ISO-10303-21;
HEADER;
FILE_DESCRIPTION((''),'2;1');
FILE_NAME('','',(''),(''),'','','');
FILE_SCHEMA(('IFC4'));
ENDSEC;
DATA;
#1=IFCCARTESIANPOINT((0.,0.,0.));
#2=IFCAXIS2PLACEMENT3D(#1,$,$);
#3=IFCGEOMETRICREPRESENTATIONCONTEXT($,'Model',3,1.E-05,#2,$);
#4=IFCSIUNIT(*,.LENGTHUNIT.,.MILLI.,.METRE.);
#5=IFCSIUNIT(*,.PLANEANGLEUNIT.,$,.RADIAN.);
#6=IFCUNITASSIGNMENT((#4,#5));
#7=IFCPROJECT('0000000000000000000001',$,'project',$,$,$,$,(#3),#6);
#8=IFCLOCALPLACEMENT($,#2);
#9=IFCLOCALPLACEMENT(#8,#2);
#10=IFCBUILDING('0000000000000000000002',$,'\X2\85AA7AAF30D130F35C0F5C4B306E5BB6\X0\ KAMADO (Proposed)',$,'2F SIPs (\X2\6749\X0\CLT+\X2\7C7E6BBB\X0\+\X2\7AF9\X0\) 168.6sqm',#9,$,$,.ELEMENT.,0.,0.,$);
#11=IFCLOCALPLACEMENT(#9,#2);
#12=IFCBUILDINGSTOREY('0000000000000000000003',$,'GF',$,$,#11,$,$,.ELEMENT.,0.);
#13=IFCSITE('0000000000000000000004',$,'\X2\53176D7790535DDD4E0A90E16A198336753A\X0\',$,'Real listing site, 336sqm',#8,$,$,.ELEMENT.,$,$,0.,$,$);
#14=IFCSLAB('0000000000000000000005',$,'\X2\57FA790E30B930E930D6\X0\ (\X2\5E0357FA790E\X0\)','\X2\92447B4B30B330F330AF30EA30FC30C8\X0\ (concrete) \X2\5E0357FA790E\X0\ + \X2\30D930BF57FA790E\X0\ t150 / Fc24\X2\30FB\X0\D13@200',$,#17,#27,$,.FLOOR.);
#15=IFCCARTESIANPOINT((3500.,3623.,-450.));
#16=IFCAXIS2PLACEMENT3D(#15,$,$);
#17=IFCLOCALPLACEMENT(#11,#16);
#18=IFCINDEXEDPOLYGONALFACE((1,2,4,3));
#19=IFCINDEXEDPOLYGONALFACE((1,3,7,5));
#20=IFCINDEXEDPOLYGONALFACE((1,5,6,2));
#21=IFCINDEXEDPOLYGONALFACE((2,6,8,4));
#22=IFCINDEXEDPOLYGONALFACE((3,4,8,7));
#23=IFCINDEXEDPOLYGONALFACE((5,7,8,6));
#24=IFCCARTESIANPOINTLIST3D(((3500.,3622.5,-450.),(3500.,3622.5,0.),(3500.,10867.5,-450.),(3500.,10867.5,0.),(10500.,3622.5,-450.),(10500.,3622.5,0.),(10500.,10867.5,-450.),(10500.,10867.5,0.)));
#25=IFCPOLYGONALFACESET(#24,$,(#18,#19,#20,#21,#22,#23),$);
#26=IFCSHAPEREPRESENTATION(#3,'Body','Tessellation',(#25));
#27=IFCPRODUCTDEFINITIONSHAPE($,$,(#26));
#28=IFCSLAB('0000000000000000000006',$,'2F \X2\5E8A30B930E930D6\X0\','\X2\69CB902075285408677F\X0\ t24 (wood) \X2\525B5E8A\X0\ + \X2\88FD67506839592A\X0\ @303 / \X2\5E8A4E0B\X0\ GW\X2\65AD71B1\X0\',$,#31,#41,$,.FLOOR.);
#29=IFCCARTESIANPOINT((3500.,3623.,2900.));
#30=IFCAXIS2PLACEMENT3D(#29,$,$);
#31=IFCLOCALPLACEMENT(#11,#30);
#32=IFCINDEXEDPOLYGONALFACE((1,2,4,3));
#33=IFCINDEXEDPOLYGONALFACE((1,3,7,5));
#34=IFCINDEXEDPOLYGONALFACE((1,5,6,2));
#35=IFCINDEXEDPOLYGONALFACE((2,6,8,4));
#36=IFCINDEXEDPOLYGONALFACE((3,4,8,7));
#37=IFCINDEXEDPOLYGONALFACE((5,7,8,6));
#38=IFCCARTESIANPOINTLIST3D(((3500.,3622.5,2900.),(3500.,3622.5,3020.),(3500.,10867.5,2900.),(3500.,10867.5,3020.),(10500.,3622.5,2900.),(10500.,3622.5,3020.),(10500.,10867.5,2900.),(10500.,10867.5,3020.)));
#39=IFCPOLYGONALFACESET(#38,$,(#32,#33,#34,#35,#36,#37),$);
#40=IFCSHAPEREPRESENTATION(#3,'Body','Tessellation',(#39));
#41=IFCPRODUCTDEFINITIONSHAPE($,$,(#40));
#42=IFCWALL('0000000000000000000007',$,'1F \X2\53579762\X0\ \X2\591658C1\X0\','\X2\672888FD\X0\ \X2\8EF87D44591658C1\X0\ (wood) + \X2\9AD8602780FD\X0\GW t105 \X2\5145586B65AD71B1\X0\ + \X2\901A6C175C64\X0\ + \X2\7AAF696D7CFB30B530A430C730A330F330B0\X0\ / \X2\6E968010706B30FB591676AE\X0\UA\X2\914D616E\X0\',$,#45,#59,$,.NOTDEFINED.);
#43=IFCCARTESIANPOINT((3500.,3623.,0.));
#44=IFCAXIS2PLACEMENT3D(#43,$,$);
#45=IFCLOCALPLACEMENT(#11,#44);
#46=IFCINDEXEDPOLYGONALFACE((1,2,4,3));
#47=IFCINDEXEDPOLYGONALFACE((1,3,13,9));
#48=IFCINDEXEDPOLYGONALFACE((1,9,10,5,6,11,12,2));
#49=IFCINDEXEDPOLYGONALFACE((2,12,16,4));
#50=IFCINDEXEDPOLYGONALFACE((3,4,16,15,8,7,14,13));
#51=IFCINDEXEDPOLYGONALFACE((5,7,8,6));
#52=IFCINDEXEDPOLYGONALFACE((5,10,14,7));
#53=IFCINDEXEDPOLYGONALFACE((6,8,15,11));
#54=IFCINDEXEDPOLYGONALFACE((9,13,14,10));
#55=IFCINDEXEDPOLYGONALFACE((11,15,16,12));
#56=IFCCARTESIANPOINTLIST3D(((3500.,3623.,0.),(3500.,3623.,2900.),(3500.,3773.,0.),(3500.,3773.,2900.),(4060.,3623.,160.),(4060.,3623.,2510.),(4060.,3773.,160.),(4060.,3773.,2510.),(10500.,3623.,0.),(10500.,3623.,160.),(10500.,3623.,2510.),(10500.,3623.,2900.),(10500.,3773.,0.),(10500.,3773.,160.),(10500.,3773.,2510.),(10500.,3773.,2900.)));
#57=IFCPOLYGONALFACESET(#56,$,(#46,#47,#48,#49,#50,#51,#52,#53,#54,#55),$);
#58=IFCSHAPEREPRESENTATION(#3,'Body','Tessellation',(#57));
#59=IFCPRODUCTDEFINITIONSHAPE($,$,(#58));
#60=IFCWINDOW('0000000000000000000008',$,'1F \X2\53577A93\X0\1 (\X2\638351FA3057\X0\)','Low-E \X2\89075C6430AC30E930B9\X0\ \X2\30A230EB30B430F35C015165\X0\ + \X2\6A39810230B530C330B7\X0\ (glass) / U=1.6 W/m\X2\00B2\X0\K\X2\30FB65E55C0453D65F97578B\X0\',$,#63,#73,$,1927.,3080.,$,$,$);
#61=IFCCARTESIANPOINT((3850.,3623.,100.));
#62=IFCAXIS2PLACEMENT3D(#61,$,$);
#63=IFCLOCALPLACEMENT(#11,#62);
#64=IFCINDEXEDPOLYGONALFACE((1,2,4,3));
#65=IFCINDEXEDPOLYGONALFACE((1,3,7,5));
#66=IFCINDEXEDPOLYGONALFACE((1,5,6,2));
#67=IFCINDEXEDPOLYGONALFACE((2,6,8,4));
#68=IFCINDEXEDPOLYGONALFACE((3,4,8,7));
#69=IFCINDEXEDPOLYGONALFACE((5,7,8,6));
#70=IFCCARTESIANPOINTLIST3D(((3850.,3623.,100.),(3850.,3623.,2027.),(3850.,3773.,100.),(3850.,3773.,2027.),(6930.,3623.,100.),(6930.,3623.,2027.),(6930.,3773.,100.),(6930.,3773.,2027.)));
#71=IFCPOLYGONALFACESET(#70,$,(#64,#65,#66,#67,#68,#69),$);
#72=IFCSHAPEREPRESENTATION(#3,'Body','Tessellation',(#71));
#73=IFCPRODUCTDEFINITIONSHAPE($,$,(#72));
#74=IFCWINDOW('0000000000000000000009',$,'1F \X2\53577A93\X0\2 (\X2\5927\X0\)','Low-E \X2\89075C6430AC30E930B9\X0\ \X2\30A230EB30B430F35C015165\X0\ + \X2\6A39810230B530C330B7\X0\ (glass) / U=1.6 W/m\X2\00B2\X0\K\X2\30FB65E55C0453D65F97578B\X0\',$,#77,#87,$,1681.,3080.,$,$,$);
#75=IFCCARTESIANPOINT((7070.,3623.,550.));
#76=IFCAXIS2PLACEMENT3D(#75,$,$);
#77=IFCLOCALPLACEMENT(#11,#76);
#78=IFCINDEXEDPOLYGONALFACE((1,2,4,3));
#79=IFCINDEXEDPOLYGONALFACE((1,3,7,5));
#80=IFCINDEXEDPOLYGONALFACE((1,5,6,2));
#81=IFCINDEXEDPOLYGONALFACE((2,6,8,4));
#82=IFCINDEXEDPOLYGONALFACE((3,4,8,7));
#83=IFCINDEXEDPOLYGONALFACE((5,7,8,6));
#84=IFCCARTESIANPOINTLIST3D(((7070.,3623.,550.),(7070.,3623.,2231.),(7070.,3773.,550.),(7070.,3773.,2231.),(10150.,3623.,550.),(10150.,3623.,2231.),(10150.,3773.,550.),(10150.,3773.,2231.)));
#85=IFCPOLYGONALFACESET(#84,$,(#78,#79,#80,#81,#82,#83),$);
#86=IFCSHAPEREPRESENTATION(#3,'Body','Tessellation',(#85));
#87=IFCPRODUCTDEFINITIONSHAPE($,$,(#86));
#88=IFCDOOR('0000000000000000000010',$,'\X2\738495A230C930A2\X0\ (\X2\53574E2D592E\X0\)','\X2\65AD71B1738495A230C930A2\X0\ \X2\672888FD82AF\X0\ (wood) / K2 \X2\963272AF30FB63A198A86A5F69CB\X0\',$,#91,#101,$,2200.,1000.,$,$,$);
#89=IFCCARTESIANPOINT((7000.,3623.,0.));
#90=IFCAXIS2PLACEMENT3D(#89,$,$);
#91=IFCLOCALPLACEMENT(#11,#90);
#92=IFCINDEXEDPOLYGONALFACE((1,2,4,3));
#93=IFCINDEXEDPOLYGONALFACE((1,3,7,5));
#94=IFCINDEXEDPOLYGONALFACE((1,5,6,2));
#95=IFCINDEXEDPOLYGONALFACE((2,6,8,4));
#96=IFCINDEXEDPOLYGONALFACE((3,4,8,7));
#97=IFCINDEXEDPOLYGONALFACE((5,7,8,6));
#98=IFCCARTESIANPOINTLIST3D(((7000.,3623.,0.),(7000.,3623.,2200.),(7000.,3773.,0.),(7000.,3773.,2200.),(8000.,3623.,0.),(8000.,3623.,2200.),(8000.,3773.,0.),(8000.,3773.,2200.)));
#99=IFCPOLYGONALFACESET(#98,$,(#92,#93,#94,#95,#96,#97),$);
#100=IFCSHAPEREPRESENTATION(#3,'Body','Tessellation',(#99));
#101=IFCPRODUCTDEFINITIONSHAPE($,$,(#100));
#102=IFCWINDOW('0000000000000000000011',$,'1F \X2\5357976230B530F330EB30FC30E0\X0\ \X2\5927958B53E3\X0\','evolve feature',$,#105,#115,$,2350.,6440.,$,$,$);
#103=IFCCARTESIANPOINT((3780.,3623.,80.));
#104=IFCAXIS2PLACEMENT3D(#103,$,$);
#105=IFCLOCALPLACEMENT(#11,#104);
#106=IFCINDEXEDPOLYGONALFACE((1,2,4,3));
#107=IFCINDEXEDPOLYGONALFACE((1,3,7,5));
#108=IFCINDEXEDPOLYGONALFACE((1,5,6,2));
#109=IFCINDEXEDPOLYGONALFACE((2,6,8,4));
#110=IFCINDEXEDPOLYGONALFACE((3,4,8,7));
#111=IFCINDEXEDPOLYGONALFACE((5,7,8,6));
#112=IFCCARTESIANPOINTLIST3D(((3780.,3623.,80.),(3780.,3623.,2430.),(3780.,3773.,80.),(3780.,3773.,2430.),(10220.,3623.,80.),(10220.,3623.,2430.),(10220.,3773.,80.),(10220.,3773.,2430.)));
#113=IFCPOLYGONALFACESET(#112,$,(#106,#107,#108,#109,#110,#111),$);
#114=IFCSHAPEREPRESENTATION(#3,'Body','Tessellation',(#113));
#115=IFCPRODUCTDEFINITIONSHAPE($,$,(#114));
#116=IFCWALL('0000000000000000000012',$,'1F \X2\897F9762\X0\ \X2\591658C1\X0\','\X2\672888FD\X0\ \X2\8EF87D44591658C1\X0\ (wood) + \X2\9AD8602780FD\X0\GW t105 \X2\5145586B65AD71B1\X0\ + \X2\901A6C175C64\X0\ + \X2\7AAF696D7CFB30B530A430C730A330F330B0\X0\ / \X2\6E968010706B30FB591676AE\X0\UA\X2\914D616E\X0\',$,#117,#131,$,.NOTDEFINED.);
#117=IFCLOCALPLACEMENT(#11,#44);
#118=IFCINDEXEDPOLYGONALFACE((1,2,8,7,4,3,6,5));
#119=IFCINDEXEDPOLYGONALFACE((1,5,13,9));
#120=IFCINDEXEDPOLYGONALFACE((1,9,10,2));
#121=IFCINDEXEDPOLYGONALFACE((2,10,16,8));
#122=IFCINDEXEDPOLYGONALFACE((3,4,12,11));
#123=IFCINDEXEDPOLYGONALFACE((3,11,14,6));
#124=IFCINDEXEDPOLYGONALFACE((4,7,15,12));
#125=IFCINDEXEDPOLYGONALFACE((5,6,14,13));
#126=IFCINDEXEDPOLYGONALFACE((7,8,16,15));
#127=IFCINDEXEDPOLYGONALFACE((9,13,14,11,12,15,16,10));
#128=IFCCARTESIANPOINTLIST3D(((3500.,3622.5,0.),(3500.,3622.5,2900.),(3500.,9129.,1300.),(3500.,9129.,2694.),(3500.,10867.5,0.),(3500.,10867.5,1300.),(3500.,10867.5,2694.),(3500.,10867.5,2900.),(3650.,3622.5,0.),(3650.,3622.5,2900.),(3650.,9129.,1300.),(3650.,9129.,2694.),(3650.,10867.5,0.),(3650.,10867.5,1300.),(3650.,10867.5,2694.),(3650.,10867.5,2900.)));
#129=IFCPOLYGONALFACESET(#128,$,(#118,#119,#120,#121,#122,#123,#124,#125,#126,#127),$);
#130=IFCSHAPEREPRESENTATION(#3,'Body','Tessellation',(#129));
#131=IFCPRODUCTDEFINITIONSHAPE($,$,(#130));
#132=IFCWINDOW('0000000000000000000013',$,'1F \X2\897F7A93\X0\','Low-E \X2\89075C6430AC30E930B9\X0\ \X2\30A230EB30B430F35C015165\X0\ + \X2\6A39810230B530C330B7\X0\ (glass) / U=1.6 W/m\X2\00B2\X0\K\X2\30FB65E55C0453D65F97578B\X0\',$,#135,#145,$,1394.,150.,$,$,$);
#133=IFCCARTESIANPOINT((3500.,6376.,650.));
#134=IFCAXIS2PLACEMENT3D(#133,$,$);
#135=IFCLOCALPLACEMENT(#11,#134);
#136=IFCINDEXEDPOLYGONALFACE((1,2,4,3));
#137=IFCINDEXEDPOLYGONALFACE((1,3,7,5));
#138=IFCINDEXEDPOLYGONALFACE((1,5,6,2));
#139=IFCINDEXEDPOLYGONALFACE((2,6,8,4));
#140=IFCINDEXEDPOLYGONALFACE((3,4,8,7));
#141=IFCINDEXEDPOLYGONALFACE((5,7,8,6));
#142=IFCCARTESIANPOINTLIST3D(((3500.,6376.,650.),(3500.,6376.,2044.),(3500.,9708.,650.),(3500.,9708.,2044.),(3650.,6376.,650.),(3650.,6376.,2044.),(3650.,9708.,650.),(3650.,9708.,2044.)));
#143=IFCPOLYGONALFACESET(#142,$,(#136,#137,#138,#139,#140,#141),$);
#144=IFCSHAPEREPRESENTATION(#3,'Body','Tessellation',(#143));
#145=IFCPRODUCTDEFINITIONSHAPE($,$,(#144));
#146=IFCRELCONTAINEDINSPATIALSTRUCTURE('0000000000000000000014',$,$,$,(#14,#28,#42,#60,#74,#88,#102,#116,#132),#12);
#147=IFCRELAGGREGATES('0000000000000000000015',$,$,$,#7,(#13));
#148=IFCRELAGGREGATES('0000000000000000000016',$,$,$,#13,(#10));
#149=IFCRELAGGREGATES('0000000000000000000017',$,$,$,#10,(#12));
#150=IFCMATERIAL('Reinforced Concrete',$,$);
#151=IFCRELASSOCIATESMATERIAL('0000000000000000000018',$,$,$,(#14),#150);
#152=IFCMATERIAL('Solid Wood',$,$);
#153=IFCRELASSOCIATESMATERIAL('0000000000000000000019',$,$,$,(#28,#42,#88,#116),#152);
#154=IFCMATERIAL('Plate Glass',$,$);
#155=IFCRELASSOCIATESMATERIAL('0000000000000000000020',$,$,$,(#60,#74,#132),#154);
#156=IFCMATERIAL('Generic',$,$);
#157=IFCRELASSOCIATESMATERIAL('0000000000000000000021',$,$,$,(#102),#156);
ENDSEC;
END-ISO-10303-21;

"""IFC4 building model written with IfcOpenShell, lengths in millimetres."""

from ifc_helpers import new_model, si_unit, frame, frame_2d, origin, place, context, project, spatial, rectangle, extrude, material, element, fill, save


model = new_model("IFC4")

# Units and contexts
model_context = context("Model", 3, precision=1e-05, world=origin())
ifc_project = project(units=[si_unit("LENGTHUNIT", "METRE", prefix="MILLI"), si_unit("PLANEANGLEUNIT", "RADIAN")], contexts=[model_context])

# Site, building, storey
site_placement = place(None, origin())
site = spatial("IfcSite", under=ifc_project, at=site_placement, Name="北海道川上郡標茶町", ObjectType="Real listing site, 336sqm", CompositionType="ELEMENT", RefElevation=0.0)
building_placement = place(site_placement, origin())
building = spatial("IfcBuilding", under=site, at=building_placement, Name="薪窯パン小屋の家 KAMADO (Proposed)", ObjectType="2F SIPs (杉CLT+籾殻+竹) 168.6sqm", CompositionType="ELEMENT", ElevationOfRefHeight=0.0, ElevationOfTerrain=0.0)
storey_placement = place(building_placement, origin())
storey = spatial("IfcBuildingStorey", under=building, at=storey_placement, Name="GF", CompositionType="ELEMENT", Elevation=0.0)

# Slabs
ifc_material_1 = material(Name="Reinforced Concrete")
slab_1_placement = place(storey_placement, frame((3500.0, 3623.0, -450.0)))
element("IfcSlab", 1, at=slab_1_placement, inside=storey, material=ifc_material_1, Name="基礎スラブ (布基礎)", Description="鉄筋コンクリート (concrete) 布基礎 + ベタ基礎 t150 / Fc24・D13@200", PredefinedType="FLOOR", context=model_context, shape_type="SweptSolid", body=[
    extrude(rectangle(XDim=7000.0, YDim=7245.0, at=frame_2d((3500.0, 3622.0))), frame((3500.0, 3623.0, -450.0)), (0.0, 0.0, 1.0), 450.0),
])
ifc_material_2 = material(Name="Solid Wood")
slab_2_placement = place(storey_placement, frame((3500.0, 3623.0, 2900.0)))
element("IfcSlab", 2, at=slab_2_placement, inside=storey, material=ifc_material_2, Name="2F 床スラブ", Description="構造用合板 t24 (wood) 剛床 + 製材根太 @303 / 床下 GW断熱", PredefinedType="FLOOR", context=model_context, shape_type="SweptSolid", body=[
    extrude(rectangle(XDim=7000.0, YDim=7245.0, at=frame_2d((3500.0, 3622.0))), frame((3500.0, 3623.0, 2900.0)), (0.0, 0.0, 1.0), 120.0),
])
ifc_material_3 = material(Name="Generic")

# Wall, openings, windows, door
wall_1_placement = place(storey_placement, frame((3500.0, 3623.0, 0.0)))
wall_1 = element("IfcWall", 3, at=wall_1_placement, inside=storey, material=ifc_material_2, Name="1F 南面 外壁", Description="木製 軸組外壁 (wood) + 高性能GW t105 充填断熱 + 通気層 + 窯業系サイディング / 準耐火・外皮UA配慮", PredefinedType="NOTDEFINED", context=model_context, shape_type="SweptSolid", body=[
    extrude(rectangle(XDim=7000.0, YDim=150.0, at=frame_2d((3500.0, 75.0))), frame((3500.0, 3623.0, 0.0)), (0.0, 0.0, 1.0), 2900.0),
])
opening_1_placement = place(storey_placement, frame((3850.0, 3623.0, 100.0)))
opening_1 = element("IfcOpeningElement", 4, at=opening_1_placement, cuts=wall_1, PredefinedType="NOTDEFINED", context=model_context, shape_type="SweptSolid", body=[
    extrude(rectangle(XDim=3080.0, YDim=150.0, at=frame_2d((1540.0, 75.0))), frame((3850.0, 3623.0, 100.0)), (0.0, 0.0, 1.0), 1927.0),
])
opening_2_placement = place(storey_placement, frame((7070.0, 3623.0, 550.0)))
opening_2 = element("IfcOpeningElement", 5, at=opening_2_placement, cuts=wall_1, PredefinedType="NOTDEFINED", context=model_context, shape_type="SweptSolid", body=[
    extrude(rectangle(XDim=3080.0, YDim=150.0, at=frame_2d((1540.0, 75.0))), frame((7070.0, 3623.0, 550.0)), (0.0, 0.0, 1.0), 1681.0),
])
opening_3_placement = place(storey_placement, frame((7000.0, 3623.0, 0.0)))
opening_3 = element("IfcOpeningElement", 6, at=opening_3_placement, cuts=wall_1, PredefinedType="NOTDEFINED", context=model_context, shape_type="SweptSolid", body=[
    extrude(rectangle(XDim=1000.0, YDim=150.0, at=frame_2d((500.0, 75.0))), frame((7000.0, 3623.0, 0.0)), (0.0, 0.0, 1.0), 2200.0),
])
opening_4_placement = place(storey_placement, frame((3780.0, 3623.0, 80.0)))
opening_4 = element("IfcOpeningElement", 7, at=opening_4_placement, cuts=wall_1, PredefinedType="NOTDEFINED", context=model_context, shape_type="SweptSolid", body=[
    extrude(rectangle(XDim=6440.0, YDim=150.0, at=frame_2d((3220.0, 75.0))), frame((3780.0, 3623.0, 80.0)), (0.0, 0.0, 1.0), 2350.0),
])
ifc_material_4 = material(Name="Plate Glass")
window_1_placement = place(storey_placement, frame((3850.0, 3623.0, 100.0)))
window_1 = element("IfcWindow", 8, at=window_1_placement, inside=storey, material=ifc_material_4, Name="1F 南窓1 (掃出し)", Description="Low-E 複層ガラス アルゴン封入 + 樹脂サッシ (glass) / U=1.6 W/m²K・日射取得型", OverallHeight=1927.0, OverallWidth=3080.0, context=model_context, shape_type="SweptSolid", body=[
    extrude(rectangle(XDim=3080.0, YDim=150.0, at=frame_2d((1540.0, 75.0))), frame((3850.0, 3623.0, 100.0)), (0.0, 0.0, 1.0), 1927.0),
])
fill(opening_1, window_1)
window_2_placement = place(storey_placement, frame((7070.0, 3623.0, 550.0)))
window_2 = element("IfcWindow", 9, at=window_2_placement, inside=storey, material=ifc_material_4, Name="1F 南窓2 (大)", Description="Low-E 複層ガラス アルゴン封入 + 樹脂サッシ (glass) / U=1.6 W/m²K・日射取得型", OverallHeight=1681.0, OverallWidth=3080.0, context=model_context, shape_type="SweptSolid", body=[
    extrude(rectangle(XDim=3080.0, YDim=150.0, at=frame_2d((1540.0, 75.0))), frame((7070.0, 3623.0, 550.0)), (0.0, 0.0, 1.0), 1681.0),
])
fill(opening_2, window_2)
door_placement = place(storey_placement, frame((7000.0, 3623.0, 0.0)))
door = element("IfcDoor", 10, at=door_placement, inside=storey, material=ifc_material_2, Name="玄関ドア (南中央)", Description="断熱玄関ドア 木製芯 (wood) / K2 防犯・採風機構", OverallHeight=2200.0, OverallWidth=1000.0, context=model_context, shape_type="SweptSolid", body=[
    extrude(rectangle(XDim=1000.0, YDim=150.0, at=frame_2d((500.0, 75.0))), frame((7000.0, 3623.0, 0.0)), (0.0, 0.0, 1.0), 2200.0),
])
fill(opening_3, door)
window_3_placement = place(storey_placement, frame((3780.0, 3623.0, 80.0)))
window_3 = element("IfcWindow", 11, at=window_3_placement, inside=storey, material=ifc_material_3, Name="1F 南面サンルーム 大開口", Description="evolve feature", OverallHeight=2350.0, OverallWidth=6440.0, context=model_context, shape_type="SweptSolid", body=[
    extrude(rectangle(XDim=6440.0, YDim=150.0, at=frame_2d((3220.0, 75.0))), frame((3780.0, 3623.0, 80.0)), (0.0, 0.0, 1.0), 2350.0),
])
fill(opening_4, window_3)

# Wall, opening, window
wall_2_placement = place(storey_placement, frame((3500.0, 3623.0, 0.0)))
wall_2 = element("IfcWall", 12, at=wall_2_placement, inside=storey, material=ifc_material_2, Name="1F 西面 外壁", Description="木製 軸組外壁 (wood) + 高性能GW t105 充填断熱 + 通気層 + 窯業系サイディング / 準耐火・外皮UA配慮", PredefinedType="NOTDEFINED", context=model_context, shape_type="SweptSolid", body=[
    extrude(rectangle(XDim=150.0, YDim=7245.0, at=frame_2d((75.0, 3622.0))), frame((3500.0, 3623.0, 0.0)), (0.0, 0.0, 1.0), 2900.0),
])
opening_5_placement = place(storey_placement, frame((3500.0, 6376.0, 650.0)))
opening_5 = element("IfcOpeningElement", 13, at=opening_5_placement, cuts=wall_2, PredefinedType="NOTDEFINED", context=model_context, shape_type="SweptSolid", body=[
    extrude(rectangle(XDim=150.0, YDim=3332.0, at=frame_2d((75.0, 1666.0))), frame((3500.0, 6376.0, 650.0)), (0.0, 0.0, 1.0), 1394.0),
])
window_4_placement = place(storey_placement, frame((3500.0, 6376.0, 650.0)))
window_4 = element("IfcWindow", 14, at=window_4_placement, inside=storey, material=ifc_material_4, Name="1F 西窓", Description="Low-E 複層ガラス アルゴン封入 + 樹脂サッシ (glass) / U=1.6 W/m²K・日射取得型", OverallHeight=1394.0, OverallWidth=150.0, context=model_context, shape_type="SweptSolid", body=[
    extrude(rectangle(XDim=150.0, YDim=3332.0, at=frame_2d((75.0, 1666.0))), frame((3500.0, 6376.0, 650.0)), (0.0, 0.0, 1.0), 1394.0),
])
fill(opening_5, window_4)

save(model, "model.ifc")
